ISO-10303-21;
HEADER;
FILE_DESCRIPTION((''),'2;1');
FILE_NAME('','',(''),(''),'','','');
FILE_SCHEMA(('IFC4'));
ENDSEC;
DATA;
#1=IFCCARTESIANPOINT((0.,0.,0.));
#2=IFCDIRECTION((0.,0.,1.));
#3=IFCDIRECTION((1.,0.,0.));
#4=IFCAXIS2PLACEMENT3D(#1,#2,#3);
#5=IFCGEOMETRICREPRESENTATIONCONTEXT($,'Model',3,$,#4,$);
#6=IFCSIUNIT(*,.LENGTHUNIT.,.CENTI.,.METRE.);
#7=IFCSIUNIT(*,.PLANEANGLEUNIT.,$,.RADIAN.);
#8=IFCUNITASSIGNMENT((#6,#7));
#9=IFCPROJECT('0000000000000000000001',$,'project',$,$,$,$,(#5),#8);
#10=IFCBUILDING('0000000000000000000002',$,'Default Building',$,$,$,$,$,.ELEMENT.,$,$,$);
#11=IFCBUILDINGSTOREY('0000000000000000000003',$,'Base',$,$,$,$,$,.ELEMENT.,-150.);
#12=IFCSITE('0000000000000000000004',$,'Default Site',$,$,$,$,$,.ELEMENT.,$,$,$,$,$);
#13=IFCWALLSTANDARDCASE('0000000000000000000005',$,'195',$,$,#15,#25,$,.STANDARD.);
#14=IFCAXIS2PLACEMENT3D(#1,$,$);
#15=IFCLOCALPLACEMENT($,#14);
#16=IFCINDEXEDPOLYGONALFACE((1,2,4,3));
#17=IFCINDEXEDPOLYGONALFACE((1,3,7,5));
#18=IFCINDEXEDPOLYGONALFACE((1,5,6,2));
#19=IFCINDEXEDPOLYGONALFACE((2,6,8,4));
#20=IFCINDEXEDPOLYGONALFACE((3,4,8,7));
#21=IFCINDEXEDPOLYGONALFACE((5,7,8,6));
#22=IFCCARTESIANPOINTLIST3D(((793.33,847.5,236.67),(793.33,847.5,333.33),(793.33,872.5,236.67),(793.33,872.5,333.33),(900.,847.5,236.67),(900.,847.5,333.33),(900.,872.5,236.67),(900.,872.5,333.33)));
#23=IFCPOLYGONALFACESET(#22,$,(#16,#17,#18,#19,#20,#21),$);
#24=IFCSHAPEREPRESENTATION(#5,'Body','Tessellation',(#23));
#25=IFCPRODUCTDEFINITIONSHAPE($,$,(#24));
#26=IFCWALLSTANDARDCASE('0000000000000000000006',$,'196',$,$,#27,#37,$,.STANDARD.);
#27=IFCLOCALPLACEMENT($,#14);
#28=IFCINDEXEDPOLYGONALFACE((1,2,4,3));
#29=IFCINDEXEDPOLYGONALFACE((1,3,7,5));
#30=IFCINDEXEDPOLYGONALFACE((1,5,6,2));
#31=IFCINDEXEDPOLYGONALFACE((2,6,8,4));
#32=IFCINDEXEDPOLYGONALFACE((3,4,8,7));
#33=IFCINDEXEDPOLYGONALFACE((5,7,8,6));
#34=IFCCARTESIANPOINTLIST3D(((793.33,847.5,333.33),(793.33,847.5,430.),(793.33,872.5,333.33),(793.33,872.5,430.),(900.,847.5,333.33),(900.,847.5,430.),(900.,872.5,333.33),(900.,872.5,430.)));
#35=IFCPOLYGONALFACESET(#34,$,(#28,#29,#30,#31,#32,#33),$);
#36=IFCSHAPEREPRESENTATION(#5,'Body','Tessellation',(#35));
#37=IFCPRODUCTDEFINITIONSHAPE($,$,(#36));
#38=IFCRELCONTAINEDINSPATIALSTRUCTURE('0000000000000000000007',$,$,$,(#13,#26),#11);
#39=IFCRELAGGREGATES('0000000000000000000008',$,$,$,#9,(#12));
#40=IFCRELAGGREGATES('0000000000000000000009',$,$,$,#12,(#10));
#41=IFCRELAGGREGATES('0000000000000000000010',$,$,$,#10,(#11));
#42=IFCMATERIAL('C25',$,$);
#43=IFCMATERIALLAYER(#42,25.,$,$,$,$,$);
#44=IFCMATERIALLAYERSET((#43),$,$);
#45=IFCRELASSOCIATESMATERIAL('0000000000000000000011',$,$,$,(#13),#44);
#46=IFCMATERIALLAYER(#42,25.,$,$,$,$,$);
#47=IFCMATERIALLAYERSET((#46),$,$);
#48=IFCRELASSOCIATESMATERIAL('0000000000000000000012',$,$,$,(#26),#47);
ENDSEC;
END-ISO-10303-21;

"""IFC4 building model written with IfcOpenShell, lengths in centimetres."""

from ifc_helpers import new_model, si_unit, frame, origin_with_axes, origin_2d_with_axis, place, context, project, spatial, rectangle, extrude, material, layer, layer_set, layer_usage, element, save


model = new_model("IFC4")

# Units and contexts
model_context = context("Model", 3, world=origin_with_axes())
ifc_project = project(units=[si_unit("LENGTHUNIT", "METRE", prefix="CENTI"), si_unit("PLANEANGLEUNIT", "RADIAN")], contexts=[model_context])

# Site, building, storey
site = spatial("IfcSite", under=ifc_project, Name="Default Site", CompositionType="ELEMENT")
building = spatial("IfcBuilding", under=site, Name="Default Building", CompositionType="ELEMENT")
storey = spatial("IfcBuildingStorey", under=building, Name="Base", CompositionType="ELEMENT", Elevation=-150.0)

# Walls
ifc_material = material(Name="C25")
ifc_layer_1 = layer(ifc_material, 25.0)
ifc_layer_set_1 = layer_set([ifc_layer_1])
ifc_layer_usage_1 = layer_usage(ifc_layer_set_1, "AXIS2", "POSITIVE", -25.0)
wall_1_placement = place(None, frame((846.67, 860.0, 236.67), z_axis=(0.0, 0.0, 1.0), x_axis=(1.0, 0.0, 0.0)))
element("IfcWallStandardCase", 1, at=wall_1_placement, inside=storey, material=ifc_layer_usage_1, Name="195", PredefinedType="STANDARD", context=model_context, shape_type="SweptSolid", body=[
    extrude(rectangle(XDim=106.67, YDim=25.0, at=origin_2d_with_axis()), origin_with_axes(), (0.0, 0.0, 1.0), 96.67),
])
ifc_layer_2 = layer(ifc_material, 25.0)
ifc_layer_set_2 = layer_set([ifc_layer_2])
ifc_layer_usage_2 = layer_usage(ifc_layer_set_2, "AXIS2", "POSITIVE", -25.0)
wall_2_placement = place(None, frame((846.67, 860.0, 333.33), z_axis=(0.0, 0.0, 1.0), x_axis=(1.0, 0.0, 0.0)))
element("IfcWallStandardCase", 2, at=wall_2_placement, inside=storey, material=ifc_layer_usage_2, Name="196", PredefinedType="STANDARD", context=model_context, shape_type="SweptSolid", body=[
    extrude(rectangle(XDim=106.67, YDim=25.0, at=origin_2d_with_axis()), origin_with_axes(), (0.0, 0.0, 1.0), 96.67),
])

save(model, "model.ifc")
